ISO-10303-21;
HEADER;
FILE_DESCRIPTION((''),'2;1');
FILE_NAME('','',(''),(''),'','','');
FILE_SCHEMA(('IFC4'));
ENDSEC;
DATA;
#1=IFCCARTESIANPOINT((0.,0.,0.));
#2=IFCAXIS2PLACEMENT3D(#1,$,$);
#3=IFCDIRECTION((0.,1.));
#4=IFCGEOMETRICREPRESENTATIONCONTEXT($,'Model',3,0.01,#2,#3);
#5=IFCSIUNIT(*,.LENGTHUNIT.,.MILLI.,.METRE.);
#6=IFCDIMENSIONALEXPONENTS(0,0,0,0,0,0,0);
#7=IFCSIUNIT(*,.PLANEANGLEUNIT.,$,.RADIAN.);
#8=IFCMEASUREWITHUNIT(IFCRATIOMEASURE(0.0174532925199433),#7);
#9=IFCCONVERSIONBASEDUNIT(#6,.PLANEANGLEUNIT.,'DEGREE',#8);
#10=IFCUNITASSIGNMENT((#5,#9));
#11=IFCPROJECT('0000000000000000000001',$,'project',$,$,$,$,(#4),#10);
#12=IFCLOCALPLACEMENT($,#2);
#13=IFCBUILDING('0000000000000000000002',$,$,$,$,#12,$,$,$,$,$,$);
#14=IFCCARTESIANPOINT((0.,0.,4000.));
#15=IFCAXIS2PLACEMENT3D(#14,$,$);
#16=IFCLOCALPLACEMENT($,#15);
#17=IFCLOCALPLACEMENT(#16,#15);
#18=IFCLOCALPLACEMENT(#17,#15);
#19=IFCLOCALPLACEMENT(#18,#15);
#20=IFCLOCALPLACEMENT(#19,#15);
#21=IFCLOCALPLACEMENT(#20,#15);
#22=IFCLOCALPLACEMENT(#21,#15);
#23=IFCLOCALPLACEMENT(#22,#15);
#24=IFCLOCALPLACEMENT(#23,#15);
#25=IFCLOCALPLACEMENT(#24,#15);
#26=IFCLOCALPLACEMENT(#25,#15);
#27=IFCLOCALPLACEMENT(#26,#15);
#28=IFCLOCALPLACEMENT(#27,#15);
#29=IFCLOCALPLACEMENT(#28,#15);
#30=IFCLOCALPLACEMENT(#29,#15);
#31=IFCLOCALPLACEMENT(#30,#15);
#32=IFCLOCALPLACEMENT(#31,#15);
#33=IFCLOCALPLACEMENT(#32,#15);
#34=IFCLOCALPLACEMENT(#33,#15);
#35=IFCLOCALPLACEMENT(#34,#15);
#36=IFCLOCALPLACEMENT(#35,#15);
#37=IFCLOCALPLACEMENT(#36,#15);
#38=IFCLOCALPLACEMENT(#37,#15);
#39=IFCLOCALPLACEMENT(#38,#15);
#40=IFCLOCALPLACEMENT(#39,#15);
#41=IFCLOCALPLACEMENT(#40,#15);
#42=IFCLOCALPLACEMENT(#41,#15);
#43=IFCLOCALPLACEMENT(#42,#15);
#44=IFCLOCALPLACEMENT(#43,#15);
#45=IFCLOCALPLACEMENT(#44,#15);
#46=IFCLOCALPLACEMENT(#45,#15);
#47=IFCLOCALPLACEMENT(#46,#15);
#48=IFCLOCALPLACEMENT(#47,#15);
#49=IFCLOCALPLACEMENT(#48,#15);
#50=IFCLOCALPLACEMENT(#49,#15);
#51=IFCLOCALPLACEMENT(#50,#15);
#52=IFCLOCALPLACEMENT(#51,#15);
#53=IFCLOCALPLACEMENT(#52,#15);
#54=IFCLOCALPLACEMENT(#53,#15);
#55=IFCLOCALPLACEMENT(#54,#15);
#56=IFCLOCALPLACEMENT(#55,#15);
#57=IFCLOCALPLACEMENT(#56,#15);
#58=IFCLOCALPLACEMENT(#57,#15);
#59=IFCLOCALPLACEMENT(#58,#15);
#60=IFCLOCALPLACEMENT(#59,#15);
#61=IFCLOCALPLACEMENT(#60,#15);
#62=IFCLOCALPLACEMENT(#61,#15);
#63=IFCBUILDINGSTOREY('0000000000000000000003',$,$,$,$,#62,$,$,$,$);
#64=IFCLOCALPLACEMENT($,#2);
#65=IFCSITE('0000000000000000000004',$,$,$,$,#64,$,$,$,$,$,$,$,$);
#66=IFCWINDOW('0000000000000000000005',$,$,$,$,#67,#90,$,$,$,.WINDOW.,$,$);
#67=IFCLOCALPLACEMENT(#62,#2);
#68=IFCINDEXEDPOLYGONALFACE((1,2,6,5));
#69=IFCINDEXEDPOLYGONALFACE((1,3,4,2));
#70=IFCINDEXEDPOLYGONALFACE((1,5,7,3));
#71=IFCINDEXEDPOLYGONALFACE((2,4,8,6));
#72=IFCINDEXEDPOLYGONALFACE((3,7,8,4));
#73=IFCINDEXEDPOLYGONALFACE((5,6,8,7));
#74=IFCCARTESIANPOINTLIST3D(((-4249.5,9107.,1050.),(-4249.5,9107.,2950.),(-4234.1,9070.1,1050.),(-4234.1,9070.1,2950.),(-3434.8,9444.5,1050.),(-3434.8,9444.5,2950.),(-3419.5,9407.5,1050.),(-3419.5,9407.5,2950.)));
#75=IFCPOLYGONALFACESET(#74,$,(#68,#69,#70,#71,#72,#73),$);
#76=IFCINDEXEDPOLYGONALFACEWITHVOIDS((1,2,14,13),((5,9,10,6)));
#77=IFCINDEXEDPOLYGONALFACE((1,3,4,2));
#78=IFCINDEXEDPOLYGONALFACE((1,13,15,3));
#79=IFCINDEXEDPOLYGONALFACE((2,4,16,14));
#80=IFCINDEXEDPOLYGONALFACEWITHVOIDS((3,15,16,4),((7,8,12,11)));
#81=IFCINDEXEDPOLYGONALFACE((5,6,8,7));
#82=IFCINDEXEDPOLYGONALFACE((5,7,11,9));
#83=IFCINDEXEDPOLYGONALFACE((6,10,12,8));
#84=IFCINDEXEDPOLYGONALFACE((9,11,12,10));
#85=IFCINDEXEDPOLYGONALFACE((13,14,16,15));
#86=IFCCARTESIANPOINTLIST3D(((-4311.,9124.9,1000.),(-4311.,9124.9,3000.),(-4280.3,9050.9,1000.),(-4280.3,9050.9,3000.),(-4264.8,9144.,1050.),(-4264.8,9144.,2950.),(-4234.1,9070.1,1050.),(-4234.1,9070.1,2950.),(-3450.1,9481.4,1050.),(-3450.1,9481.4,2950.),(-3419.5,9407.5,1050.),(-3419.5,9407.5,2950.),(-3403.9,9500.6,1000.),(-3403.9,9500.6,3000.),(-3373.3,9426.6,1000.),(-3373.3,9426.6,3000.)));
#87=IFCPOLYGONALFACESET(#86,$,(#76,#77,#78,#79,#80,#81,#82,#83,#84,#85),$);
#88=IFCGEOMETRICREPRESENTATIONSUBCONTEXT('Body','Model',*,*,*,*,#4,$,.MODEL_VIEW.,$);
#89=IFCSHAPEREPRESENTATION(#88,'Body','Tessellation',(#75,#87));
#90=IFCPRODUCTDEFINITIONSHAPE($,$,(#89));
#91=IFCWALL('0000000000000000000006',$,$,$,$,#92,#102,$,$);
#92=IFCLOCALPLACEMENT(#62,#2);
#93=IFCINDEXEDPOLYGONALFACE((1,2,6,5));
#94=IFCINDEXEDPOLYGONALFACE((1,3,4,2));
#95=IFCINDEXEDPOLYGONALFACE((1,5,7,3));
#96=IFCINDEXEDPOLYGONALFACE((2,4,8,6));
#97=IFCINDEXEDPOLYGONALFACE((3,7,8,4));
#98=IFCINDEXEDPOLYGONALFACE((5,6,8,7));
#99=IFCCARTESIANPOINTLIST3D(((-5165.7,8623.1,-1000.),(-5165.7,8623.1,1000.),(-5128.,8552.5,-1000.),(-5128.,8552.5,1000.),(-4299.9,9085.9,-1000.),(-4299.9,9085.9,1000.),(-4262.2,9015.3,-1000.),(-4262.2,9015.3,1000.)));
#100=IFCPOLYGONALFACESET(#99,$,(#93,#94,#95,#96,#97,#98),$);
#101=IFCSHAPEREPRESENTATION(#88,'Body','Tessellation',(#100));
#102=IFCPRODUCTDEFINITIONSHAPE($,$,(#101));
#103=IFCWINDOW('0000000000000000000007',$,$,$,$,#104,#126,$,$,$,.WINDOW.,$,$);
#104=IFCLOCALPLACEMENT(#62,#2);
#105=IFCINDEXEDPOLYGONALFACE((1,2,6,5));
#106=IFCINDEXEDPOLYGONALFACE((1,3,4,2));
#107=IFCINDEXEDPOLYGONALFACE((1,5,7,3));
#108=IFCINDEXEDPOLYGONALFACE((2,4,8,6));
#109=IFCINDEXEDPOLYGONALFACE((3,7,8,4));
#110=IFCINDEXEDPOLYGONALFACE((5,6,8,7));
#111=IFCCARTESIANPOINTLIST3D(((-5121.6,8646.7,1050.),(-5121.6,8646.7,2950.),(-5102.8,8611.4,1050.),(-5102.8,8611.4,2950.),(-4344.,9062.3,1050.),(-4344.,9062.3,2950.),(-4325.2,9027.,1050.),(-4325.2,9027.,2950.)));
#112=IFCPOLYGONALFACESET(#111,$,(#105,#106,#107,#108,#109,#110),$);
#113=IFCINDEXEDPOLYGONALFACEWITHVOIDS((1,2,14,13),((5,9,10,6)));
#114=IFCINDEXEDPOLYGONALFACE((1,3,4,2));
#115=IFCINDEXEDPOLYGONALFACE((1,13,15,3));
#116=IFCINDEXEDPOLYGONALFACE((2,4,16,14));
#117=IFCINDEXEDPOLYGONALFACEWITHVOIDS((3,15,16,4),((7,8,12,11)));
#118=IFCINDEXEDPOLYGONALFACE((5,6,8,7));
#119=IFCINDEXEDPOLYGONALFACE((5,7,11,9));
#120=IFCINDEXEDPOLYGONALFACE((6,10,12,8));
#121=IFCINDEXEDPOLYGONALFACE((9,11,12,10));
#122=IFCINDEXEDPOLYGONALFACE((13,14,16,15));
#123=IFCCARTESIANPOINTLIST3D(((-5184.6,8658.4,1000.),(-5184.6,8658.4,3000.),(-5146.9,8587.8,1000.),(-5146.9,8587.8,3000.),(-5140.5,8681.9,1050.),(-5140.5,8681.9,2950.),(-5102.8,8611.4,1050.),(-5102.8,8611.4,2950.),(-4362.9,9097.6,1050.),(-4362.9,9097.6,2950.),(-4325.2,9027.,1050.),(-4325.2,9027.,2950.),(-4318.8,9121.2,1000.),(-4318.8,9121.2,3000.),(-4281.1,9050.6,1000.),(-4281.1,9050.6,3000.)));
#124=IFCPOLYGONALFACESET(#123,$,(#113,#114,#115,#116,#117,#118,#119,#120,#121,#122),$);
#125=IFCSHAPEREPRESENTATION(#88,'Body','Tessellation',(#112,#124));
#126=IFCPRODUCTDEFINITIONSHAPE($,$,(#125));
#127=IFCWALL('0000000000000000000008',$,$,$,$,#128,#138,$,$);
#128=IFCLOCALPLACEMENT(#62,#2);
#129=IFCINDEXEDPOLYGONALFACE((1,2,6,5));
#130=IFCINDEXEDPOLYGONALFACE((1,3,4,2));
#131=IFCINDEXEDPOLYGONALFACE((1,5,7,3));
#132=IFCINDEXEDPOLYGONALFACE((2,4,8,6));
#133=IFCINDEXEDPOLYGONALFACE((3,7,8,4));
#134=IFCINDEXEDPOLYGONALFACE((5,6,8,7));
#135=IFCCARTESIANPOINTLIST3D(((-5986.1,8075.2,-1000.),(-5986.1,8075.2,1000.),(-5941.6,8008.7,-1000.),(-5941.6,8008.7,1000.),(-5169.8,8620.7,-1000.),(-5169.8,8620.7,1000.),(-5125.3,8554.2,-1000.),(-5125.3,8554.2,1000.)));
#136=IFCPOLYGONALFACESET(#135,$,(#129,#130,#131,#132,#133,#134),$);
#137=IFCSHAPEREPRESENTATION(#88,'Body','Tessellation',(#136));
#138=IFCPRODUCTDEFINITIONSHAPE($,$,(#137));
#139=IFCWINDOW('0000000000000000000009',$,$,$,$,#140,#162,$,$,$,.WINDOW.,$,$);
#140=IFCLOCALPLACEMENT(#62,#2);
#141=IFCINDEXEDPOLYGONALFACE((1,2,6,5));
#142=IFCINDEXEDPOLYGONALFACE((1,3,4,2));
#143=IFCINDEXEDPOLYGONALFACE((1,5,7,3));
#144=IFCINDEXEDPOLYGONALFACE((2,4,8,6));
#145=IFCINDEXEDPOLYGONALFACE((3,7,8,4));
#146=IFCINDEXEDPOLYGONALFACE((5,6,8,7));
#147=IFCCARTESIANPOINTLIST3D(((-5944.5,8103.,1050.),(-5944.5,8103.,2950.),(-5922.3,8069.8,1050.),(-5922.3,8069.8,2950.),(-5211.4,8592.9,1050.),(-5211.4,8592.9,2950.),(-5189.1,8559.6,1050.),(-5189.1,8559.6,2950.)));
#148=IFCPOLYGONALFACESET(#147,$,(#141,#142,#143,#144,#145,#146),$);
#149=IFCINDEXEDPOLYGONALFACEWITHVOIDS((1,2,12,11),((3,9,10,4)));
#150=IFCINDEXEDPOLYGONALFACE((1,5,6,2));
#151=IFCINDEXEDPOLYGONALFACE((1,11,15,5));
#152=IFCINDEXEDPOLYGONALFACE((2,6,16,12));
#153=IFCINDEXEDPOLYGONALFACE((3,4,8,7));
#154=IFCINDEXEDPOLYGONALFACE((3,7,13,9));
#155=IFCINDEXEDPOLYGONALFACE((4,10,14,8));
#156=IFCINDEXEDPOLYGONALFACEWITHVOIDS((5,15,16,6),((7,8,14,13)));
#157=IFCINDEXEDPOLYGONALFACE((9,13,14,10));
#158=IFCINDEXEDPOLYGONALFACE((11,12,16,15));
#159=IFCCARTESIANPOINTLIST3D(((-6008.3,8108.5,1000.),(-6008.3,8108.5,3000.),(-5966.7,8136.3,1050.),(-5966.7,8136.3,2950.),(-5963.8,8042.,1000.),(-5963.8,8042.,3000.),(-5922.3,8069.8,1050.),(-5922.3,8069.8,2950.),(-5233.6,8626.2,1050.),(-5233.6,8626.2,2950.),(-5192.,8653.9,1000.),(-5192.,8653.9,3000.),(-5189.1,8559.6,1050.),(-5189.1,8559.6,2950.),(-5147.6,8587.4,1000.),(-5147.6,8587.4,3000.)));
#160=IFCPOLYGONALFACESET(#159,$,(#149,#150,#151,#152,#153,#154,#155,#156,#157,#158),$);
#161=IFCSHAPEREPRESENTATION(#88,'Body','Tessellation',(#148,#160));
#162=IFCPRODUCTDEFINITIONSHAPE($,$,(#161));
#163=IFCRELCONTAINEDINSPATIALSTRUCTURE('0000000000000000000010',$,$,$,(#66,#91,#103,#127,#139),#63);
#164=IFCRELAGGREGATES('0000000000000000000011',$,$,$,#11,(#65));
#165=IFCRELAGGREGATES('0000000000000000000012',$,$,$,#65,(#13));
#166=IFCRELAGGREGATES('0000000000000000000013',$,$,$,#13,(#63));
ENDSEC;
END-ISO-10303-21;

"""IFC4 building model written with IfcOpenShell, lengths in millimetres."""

from ifc_helpers import new_model, entity, si_unit, converted_unit, direction, frame, origin, origin_2d, place, context, subcontext, project, spatial, rectangle, extrude, element, save


model = new_model("IFC4")

# Units and contexts
model_context = context("Model", 3, precision=0.01, world=origin(), true_north=direction((0.0, 1.0)))
body_context = subcontext(model_context, "Body", "Model", "MODEL_VIEW")
ifc_project = project(units=[si_unit("LENGTHUNIT", "METRE", prefix="MILLI"), converted_unit("PLANEANGLEUNIT", "DEGREE", entity("IfcRatioMeasure", 0.0174532925199433), si_unit("PLANEANGLEUNIT", "RADIAN"), dimensions=[0, 0, 0, 0, 0, 0, 0])], contexts=[model_context])

# Site, building, storey
site_placement = place(None, origin())
site = spatial("IfcSite", under=ifc_project, at=site_placement)
building_placement = place(None, origin())
building = spatial("IfcBuilding", under=site, at=building_placement)
placement_1 = place(None, frame((0.0, 0.0, 4000.0)))
placement_2 = place(placement_1, frame((0.0, 0.0, 4000.0)))
placement_3 = place(placement_2, frame((0.0, 0.0, 4000.0)))
placement_4 = place(placement_3, frame((0.0, 0.0, 4000.0)))
placement_5 = place(placement_4, frame((0.0, 0.0, 4000.0)))
placement_6 = place(placement_5, frame((0.0, 0.0, 4000.0)))
placement_7 = place(placement_6, frame((0.0, 0.0, 4000.0)))
placement_8 = place(placement_7, frame((0.0, 0.0, 4000.0)))
placement_9 = place(placement_8, frame((0.0, 0.0, 4000.0)))
placement_10 = place(placement_9, frame((0.0, 0.0, 4000.0)))
placement_11 = place(placement_10, frame((0.0, 0.0, 4000.0)))
placement_12 = place(placement_11, frame((0.0, 0.0, 4000.0)))
placement_13 = place(placement_12, frame((0.0, 0.0, 4000.0)))
placement_14 = place(placement_13, frame((0.0, 0.0, 4000.0)))
placement_15 = place(placement_14, frame((0.0, 0.0, 4000.0)))
placement_16 = place(placement_15, frame((0.0, 0.0, 4000.0)))
placement_17 = place(placement_16, frame((0.0, 0.0, 4000.0)))
placement_18 = place(placement_17, frame((0.0, 0.0, 4000.0)))
placement_19 = place(placement_18, frame((0.0, 0.0, 4000.0)))
placement_20 = place(placement_19, frame((0.0, 0.0, 4000.0)))
placement_21 = place(placement_20, frame((0.0, 0.0, 4000.0)))
placement_22 = place(placement_21, frame((0.0, 0.0, 4000.0)))
placement_23 = place(placement_22, frame((0.0, 0.0, 4000.0)))
placement_24 = place(placement_23, frame((0.0, 0.0, 4000.0)))
placement_25 = place(placement_24, frame((0.0, 0.0, 4000.0)))
placement_26 = place(placement_25, frame((0.0, 0.0, 4000.0)))
placement_27 = place(placement_26, frame((0.0, 0.0, 4000.0)))
placement_28 = place(placement_27, frame((0.0, 0.0, 4000.0)))
placement_29 = place(placement_28, frame((0.0, 0.0, 4000.0)))
placement_30 = place(placement_29, frame((0.0, 0.0, 4000.0)))
placement_31 = place(placement_30, frame((0.0, 0.0, 4000.0)))
placement_32 = place(placement_31, frame((0.0, 0.0, 4000.0)))
placement_33 = place(placement_32, frame((0.0, 0.0, 4000.0)))
placement_34 = place(placement_33, frame((0.0, 0.0, 4000.0)))
placement_35 = place(placement_34, frame((0.0, 0.0, 4000.0)))
placement_36 = place(placement_35, frame((0.0, 0.0, 4000.0)))
placement_37 = place(placement_36, frame((0.0, 0.0, 4000.0)))
placement_38 = place(placement_37, frame((0.0, 0.0, 4000.0)))
placement_39 = place(placement_38, frame((0.0, 0.0, 4000.0)))
placement_40 = place(placement_39, frame((0.0, 0.0, 4000.0)))
placement_41 = place(placement_40, frame((0.0, 0.0, 4000.0)))
placement_42 = place(placement_41, frame((0.0, 0.0, 4000.0)))
placement_43 = place(placement_42, frame((0.0, 0.0, 4000.0)))
placement_44 = place(placement_43, frame((0.0, 0.0, 4000.0)))
placement_45 = place(placement_44, frame((0.0, 0.0, 4000.0)))
placement_46 = place(placement_45, frame((0.0, 0.0, 4000.0)))
storey_placement = place(placement_46, frame((0.0, 0.0, 4000.0)))
storey = spatial("IfcBuildingStorey", under=building, at=storey_placement)

# Shared definitions
cartesian_point_1 = entity("IfcCartesianPoint", [-440.9, -950.0])
shared_polyline = entity("IfcPolyline", [cartesian_point_1, entity("IfcCartesianPoint", [-440.9, 950.0]), entity("IfcCartesianPoint", [-440.9, 950.0]), entity("IfcCartesianPoint", [440.9, 950.0]), entity("IfcCartesianPoint", [440.9, 950.0]), entity("IfcCartesianPoint", [440.9, -950.0]), entity("IfcCartesianPoint", [440.9, -950.0]), entity("IfcCartesianPoint", [-440.9, -950.0]), cartesian_point_1])

# Window
window_1_placement = place(storey_placement, frame((-3826.8, 9238.8, 2000.0), z_axis=(0.0, 0.0, 1.0), x_axis=(-9238.795458, -3826.834002, 0.0)))
cartesian_point_2 = entity("IfcCartesianPoint", [-490.9, -1000.0])
element("IfcWindow", 1, at=window_1_placement, inside=storey, PredefinedType="WINDOW", context=body_context, shape_type="SweptSolid", body=[
    entity("IfcExtrudedAreaSolid", entity("IfcArbitraryClosedProfileDef", "AREA", None, shared_polyline), entity("IfcAxis2Placement3D", entity("IfcCartesianPoint", [0.0, 0.0, 0.0]), entity("IfcDirection", [0.0, -1.0, 0.0]), entity("IfcDirection", [1.0, 0.0, 0.0])), entity("IfcDirection", [0.0, 0.0, 1.0]), 40.0),
    entity("IfcExtrudedAreaSolid", entity("IfcArbitraryProfileDefWithVoids", "AREA", None, entity("IfcPolyline", [cartesian_point_2, entity("IfcCartesianPoint", [-490.9, 1000.0]), entity("IfcCartesianPoint", [-490.9, 1000.0]), entity("IfcCartesianPoint", [490.9, 1000.0]), entity("IfcCartesianPoint", [490.9, 1000.0]), entity("IfcCartesianPoint", [490.9, -1000.0]), entity("IfcCartesianPoint", [490.9, -1000.0]), entity("IfcCartesianPoint", [-490.9, -1000.0]), cartesian_point_2]), [shared_polyline]), entity("IfcAxis2Placement3D", entity("IfcCartesianPoint", [0.0, 0.0, 0.0]), entity("IfcDirection", [0.0, -1.0, 0.0]), entity("IfcDirection", [1.0, 0.0, 0.0])), entity("IfcDirection", [0.0, 0.0, 1.0]), 80.0),
])

# Wall
wall_1_placement = place(storey_placement, frame((-4714.0, 8819.2, -1000.0), z_axis=(0.0, 0.0, 1.0), x_axis=(-8819.213181, -4713.966363, 0.0)))
element("IfcWall", 2, at=wall_1_placement, inside=storey, context=body_context, shape_type="SweptSolid", body=[
    extrude(rectangle(XDim=981.7, YDim=80.0, at=origin_2d()), origin(), (0.0, 0.0, 1.0), 2000.0),
])

# Window
window_2_placement = place(storey_placement, frame((-4714.0, 8819.2, 2000.0), z_axis=(0.0, 0.0, 1.0), x_axis=(-8819.213181, -4713.966363, 0.0)))
cartesian_point_3 = entity("IfcCartesianPoint", [-490.9, -1000.0])
element("IfcWindow", 3, at=window_2_placement, inside=storey, PredefinedType="WINDOW", context=body_context, shape_type="SweptSolid", body=[
    entity("IfcExtrudedAreaSolid", entity("IfcArbitraryClosedProfileDef", "AREA", None, shared_polyline), entity("IfcAxis2Placement3D", entity("IfcCartesianPoint", [0.0, 0.0, 0.0]), entity("IfcDirection", [0.0, -1.0, 0.0]), entity("IfcDirection", [1.0, 0.0, 0.0])), entity("IfcDirection", [0.0, 0.0, 1.0]), 40.0),
    entity("IfcExtrudedAreaSolid", entity("IfcArbitraryProfileDefWithVoids", "AREA", None, entity("IfcPolyline", [cartesian_point_3, entity("IfcCartesianPoint", [-490.9, 1000.0]), entity("IfcCartesianPoint", [-490.9, 1000.0]), entity("IfcCartesianPoint", [490.9, 1000.0]), entity("IfcCartesianPoint", [490.9, 1000.0]), entity("IfcCartesianPoint", [490.9, -1000.0]), entity("IfcCartesianPoint", [490.9, -1000.0]), entity("IfcCartesianPoint", [-490.9, -1000.0]), cartesian_point_3]), [shared_polyline]), entity("IfcAxis2Placement3D", entity("IfcCartesianPoint", [0.0, 0.0, 0.0]), entity("IfcDirection", [0.0, -1.0, 0.0]), entity("IfcDirection", [1.0, 0.0, 0.0])), entity("IfcDirection", [0.0, 0.0, 1.0]), 80.0),
])

# Wall
wall_2_placement = place(storey_placement, frame((-5555.7, 8314.7, -1000.0), z_axis=(0.0, 0.0, 1.0), x_axis=(-8314.696534, -5555.701715, 0.0)))
element("IfcWall", 4, at=wall_2_placement, inside=storey, context=body_context, shape_type="SweptSolid", body=[
    extrude(rectangle(XDim=981.7, YDim=80.0, at=origin_2d()), origin(), (0.0, 0.0, 1.0), 2000.0),
])

# Window
window_3_placement = place(storey_placement, frame((-5555.7, 8314.7, 2000.0), z_axis=(0.0, 0.0, 1.0), x_axis=(-8314.696534, -5555.701715, 0.0)))
cartesian_point_4 = entity("IfcCartesianPoint", [-490.9, -1000.0])
element("IfcWindow", 5, at=window_3_placement, inside=storey, PredefinedType="WINDOW", context=body_context, shape_type="SweptSolid", body=[
    entity("IfcExtrudedAreaSolid", entity("IfcArbitraryClosedProfileDef", "AREA", None, shared_polyline), entity("IfcAxis2Placement3D", entity("IfcCartesianPoint", [0.0, 0.0, 0.0]), entity("IfcDirection", [0.0, -1.0, 0.0]), entity("IfcDirection", [1.0, 0.0, 0.0])), entity("IfcDirection", [0.0, 0.0, 1.0]), 40.0),
    entity("IfcExtrudedAreaSolid", entity("IfcArbitraryProfileDefWithVoids", "AREA", None, entity("IfcPolyline", [cartesian_point_4, entity("IfcCartesianPoint", [-490.9, 1000.0]), entity("IfcCartesianPoint", [-490.9, 1000.0]), entity("IfcCartesianPoint", [490.9, 1000.0]), entity("IfcCartesianPoint", [490.9, 1000.0]), entity("IfcCartesianPoint", [490.9, -1000.0]), entity("IfcCartesianPoint", [490.9, -1000.0]), entity("IfcCartesianPoint", [-490.9, -1000.0]), cartesian_point_4]), [shared_polyline]), entity("IfcAxis2Placement3D", entity("IfcCartesianPoint", [0.0, 0.0, 0.0]), entity("IfcDirection", [0.0, -1.0, 0.0]), entity("IfcDirection", [1.0, 0.0, 0.0])), entity("IfcDirection", [0.0, 0.0, 1.0]), 80.0),
])

save(model, "model.ifc")
